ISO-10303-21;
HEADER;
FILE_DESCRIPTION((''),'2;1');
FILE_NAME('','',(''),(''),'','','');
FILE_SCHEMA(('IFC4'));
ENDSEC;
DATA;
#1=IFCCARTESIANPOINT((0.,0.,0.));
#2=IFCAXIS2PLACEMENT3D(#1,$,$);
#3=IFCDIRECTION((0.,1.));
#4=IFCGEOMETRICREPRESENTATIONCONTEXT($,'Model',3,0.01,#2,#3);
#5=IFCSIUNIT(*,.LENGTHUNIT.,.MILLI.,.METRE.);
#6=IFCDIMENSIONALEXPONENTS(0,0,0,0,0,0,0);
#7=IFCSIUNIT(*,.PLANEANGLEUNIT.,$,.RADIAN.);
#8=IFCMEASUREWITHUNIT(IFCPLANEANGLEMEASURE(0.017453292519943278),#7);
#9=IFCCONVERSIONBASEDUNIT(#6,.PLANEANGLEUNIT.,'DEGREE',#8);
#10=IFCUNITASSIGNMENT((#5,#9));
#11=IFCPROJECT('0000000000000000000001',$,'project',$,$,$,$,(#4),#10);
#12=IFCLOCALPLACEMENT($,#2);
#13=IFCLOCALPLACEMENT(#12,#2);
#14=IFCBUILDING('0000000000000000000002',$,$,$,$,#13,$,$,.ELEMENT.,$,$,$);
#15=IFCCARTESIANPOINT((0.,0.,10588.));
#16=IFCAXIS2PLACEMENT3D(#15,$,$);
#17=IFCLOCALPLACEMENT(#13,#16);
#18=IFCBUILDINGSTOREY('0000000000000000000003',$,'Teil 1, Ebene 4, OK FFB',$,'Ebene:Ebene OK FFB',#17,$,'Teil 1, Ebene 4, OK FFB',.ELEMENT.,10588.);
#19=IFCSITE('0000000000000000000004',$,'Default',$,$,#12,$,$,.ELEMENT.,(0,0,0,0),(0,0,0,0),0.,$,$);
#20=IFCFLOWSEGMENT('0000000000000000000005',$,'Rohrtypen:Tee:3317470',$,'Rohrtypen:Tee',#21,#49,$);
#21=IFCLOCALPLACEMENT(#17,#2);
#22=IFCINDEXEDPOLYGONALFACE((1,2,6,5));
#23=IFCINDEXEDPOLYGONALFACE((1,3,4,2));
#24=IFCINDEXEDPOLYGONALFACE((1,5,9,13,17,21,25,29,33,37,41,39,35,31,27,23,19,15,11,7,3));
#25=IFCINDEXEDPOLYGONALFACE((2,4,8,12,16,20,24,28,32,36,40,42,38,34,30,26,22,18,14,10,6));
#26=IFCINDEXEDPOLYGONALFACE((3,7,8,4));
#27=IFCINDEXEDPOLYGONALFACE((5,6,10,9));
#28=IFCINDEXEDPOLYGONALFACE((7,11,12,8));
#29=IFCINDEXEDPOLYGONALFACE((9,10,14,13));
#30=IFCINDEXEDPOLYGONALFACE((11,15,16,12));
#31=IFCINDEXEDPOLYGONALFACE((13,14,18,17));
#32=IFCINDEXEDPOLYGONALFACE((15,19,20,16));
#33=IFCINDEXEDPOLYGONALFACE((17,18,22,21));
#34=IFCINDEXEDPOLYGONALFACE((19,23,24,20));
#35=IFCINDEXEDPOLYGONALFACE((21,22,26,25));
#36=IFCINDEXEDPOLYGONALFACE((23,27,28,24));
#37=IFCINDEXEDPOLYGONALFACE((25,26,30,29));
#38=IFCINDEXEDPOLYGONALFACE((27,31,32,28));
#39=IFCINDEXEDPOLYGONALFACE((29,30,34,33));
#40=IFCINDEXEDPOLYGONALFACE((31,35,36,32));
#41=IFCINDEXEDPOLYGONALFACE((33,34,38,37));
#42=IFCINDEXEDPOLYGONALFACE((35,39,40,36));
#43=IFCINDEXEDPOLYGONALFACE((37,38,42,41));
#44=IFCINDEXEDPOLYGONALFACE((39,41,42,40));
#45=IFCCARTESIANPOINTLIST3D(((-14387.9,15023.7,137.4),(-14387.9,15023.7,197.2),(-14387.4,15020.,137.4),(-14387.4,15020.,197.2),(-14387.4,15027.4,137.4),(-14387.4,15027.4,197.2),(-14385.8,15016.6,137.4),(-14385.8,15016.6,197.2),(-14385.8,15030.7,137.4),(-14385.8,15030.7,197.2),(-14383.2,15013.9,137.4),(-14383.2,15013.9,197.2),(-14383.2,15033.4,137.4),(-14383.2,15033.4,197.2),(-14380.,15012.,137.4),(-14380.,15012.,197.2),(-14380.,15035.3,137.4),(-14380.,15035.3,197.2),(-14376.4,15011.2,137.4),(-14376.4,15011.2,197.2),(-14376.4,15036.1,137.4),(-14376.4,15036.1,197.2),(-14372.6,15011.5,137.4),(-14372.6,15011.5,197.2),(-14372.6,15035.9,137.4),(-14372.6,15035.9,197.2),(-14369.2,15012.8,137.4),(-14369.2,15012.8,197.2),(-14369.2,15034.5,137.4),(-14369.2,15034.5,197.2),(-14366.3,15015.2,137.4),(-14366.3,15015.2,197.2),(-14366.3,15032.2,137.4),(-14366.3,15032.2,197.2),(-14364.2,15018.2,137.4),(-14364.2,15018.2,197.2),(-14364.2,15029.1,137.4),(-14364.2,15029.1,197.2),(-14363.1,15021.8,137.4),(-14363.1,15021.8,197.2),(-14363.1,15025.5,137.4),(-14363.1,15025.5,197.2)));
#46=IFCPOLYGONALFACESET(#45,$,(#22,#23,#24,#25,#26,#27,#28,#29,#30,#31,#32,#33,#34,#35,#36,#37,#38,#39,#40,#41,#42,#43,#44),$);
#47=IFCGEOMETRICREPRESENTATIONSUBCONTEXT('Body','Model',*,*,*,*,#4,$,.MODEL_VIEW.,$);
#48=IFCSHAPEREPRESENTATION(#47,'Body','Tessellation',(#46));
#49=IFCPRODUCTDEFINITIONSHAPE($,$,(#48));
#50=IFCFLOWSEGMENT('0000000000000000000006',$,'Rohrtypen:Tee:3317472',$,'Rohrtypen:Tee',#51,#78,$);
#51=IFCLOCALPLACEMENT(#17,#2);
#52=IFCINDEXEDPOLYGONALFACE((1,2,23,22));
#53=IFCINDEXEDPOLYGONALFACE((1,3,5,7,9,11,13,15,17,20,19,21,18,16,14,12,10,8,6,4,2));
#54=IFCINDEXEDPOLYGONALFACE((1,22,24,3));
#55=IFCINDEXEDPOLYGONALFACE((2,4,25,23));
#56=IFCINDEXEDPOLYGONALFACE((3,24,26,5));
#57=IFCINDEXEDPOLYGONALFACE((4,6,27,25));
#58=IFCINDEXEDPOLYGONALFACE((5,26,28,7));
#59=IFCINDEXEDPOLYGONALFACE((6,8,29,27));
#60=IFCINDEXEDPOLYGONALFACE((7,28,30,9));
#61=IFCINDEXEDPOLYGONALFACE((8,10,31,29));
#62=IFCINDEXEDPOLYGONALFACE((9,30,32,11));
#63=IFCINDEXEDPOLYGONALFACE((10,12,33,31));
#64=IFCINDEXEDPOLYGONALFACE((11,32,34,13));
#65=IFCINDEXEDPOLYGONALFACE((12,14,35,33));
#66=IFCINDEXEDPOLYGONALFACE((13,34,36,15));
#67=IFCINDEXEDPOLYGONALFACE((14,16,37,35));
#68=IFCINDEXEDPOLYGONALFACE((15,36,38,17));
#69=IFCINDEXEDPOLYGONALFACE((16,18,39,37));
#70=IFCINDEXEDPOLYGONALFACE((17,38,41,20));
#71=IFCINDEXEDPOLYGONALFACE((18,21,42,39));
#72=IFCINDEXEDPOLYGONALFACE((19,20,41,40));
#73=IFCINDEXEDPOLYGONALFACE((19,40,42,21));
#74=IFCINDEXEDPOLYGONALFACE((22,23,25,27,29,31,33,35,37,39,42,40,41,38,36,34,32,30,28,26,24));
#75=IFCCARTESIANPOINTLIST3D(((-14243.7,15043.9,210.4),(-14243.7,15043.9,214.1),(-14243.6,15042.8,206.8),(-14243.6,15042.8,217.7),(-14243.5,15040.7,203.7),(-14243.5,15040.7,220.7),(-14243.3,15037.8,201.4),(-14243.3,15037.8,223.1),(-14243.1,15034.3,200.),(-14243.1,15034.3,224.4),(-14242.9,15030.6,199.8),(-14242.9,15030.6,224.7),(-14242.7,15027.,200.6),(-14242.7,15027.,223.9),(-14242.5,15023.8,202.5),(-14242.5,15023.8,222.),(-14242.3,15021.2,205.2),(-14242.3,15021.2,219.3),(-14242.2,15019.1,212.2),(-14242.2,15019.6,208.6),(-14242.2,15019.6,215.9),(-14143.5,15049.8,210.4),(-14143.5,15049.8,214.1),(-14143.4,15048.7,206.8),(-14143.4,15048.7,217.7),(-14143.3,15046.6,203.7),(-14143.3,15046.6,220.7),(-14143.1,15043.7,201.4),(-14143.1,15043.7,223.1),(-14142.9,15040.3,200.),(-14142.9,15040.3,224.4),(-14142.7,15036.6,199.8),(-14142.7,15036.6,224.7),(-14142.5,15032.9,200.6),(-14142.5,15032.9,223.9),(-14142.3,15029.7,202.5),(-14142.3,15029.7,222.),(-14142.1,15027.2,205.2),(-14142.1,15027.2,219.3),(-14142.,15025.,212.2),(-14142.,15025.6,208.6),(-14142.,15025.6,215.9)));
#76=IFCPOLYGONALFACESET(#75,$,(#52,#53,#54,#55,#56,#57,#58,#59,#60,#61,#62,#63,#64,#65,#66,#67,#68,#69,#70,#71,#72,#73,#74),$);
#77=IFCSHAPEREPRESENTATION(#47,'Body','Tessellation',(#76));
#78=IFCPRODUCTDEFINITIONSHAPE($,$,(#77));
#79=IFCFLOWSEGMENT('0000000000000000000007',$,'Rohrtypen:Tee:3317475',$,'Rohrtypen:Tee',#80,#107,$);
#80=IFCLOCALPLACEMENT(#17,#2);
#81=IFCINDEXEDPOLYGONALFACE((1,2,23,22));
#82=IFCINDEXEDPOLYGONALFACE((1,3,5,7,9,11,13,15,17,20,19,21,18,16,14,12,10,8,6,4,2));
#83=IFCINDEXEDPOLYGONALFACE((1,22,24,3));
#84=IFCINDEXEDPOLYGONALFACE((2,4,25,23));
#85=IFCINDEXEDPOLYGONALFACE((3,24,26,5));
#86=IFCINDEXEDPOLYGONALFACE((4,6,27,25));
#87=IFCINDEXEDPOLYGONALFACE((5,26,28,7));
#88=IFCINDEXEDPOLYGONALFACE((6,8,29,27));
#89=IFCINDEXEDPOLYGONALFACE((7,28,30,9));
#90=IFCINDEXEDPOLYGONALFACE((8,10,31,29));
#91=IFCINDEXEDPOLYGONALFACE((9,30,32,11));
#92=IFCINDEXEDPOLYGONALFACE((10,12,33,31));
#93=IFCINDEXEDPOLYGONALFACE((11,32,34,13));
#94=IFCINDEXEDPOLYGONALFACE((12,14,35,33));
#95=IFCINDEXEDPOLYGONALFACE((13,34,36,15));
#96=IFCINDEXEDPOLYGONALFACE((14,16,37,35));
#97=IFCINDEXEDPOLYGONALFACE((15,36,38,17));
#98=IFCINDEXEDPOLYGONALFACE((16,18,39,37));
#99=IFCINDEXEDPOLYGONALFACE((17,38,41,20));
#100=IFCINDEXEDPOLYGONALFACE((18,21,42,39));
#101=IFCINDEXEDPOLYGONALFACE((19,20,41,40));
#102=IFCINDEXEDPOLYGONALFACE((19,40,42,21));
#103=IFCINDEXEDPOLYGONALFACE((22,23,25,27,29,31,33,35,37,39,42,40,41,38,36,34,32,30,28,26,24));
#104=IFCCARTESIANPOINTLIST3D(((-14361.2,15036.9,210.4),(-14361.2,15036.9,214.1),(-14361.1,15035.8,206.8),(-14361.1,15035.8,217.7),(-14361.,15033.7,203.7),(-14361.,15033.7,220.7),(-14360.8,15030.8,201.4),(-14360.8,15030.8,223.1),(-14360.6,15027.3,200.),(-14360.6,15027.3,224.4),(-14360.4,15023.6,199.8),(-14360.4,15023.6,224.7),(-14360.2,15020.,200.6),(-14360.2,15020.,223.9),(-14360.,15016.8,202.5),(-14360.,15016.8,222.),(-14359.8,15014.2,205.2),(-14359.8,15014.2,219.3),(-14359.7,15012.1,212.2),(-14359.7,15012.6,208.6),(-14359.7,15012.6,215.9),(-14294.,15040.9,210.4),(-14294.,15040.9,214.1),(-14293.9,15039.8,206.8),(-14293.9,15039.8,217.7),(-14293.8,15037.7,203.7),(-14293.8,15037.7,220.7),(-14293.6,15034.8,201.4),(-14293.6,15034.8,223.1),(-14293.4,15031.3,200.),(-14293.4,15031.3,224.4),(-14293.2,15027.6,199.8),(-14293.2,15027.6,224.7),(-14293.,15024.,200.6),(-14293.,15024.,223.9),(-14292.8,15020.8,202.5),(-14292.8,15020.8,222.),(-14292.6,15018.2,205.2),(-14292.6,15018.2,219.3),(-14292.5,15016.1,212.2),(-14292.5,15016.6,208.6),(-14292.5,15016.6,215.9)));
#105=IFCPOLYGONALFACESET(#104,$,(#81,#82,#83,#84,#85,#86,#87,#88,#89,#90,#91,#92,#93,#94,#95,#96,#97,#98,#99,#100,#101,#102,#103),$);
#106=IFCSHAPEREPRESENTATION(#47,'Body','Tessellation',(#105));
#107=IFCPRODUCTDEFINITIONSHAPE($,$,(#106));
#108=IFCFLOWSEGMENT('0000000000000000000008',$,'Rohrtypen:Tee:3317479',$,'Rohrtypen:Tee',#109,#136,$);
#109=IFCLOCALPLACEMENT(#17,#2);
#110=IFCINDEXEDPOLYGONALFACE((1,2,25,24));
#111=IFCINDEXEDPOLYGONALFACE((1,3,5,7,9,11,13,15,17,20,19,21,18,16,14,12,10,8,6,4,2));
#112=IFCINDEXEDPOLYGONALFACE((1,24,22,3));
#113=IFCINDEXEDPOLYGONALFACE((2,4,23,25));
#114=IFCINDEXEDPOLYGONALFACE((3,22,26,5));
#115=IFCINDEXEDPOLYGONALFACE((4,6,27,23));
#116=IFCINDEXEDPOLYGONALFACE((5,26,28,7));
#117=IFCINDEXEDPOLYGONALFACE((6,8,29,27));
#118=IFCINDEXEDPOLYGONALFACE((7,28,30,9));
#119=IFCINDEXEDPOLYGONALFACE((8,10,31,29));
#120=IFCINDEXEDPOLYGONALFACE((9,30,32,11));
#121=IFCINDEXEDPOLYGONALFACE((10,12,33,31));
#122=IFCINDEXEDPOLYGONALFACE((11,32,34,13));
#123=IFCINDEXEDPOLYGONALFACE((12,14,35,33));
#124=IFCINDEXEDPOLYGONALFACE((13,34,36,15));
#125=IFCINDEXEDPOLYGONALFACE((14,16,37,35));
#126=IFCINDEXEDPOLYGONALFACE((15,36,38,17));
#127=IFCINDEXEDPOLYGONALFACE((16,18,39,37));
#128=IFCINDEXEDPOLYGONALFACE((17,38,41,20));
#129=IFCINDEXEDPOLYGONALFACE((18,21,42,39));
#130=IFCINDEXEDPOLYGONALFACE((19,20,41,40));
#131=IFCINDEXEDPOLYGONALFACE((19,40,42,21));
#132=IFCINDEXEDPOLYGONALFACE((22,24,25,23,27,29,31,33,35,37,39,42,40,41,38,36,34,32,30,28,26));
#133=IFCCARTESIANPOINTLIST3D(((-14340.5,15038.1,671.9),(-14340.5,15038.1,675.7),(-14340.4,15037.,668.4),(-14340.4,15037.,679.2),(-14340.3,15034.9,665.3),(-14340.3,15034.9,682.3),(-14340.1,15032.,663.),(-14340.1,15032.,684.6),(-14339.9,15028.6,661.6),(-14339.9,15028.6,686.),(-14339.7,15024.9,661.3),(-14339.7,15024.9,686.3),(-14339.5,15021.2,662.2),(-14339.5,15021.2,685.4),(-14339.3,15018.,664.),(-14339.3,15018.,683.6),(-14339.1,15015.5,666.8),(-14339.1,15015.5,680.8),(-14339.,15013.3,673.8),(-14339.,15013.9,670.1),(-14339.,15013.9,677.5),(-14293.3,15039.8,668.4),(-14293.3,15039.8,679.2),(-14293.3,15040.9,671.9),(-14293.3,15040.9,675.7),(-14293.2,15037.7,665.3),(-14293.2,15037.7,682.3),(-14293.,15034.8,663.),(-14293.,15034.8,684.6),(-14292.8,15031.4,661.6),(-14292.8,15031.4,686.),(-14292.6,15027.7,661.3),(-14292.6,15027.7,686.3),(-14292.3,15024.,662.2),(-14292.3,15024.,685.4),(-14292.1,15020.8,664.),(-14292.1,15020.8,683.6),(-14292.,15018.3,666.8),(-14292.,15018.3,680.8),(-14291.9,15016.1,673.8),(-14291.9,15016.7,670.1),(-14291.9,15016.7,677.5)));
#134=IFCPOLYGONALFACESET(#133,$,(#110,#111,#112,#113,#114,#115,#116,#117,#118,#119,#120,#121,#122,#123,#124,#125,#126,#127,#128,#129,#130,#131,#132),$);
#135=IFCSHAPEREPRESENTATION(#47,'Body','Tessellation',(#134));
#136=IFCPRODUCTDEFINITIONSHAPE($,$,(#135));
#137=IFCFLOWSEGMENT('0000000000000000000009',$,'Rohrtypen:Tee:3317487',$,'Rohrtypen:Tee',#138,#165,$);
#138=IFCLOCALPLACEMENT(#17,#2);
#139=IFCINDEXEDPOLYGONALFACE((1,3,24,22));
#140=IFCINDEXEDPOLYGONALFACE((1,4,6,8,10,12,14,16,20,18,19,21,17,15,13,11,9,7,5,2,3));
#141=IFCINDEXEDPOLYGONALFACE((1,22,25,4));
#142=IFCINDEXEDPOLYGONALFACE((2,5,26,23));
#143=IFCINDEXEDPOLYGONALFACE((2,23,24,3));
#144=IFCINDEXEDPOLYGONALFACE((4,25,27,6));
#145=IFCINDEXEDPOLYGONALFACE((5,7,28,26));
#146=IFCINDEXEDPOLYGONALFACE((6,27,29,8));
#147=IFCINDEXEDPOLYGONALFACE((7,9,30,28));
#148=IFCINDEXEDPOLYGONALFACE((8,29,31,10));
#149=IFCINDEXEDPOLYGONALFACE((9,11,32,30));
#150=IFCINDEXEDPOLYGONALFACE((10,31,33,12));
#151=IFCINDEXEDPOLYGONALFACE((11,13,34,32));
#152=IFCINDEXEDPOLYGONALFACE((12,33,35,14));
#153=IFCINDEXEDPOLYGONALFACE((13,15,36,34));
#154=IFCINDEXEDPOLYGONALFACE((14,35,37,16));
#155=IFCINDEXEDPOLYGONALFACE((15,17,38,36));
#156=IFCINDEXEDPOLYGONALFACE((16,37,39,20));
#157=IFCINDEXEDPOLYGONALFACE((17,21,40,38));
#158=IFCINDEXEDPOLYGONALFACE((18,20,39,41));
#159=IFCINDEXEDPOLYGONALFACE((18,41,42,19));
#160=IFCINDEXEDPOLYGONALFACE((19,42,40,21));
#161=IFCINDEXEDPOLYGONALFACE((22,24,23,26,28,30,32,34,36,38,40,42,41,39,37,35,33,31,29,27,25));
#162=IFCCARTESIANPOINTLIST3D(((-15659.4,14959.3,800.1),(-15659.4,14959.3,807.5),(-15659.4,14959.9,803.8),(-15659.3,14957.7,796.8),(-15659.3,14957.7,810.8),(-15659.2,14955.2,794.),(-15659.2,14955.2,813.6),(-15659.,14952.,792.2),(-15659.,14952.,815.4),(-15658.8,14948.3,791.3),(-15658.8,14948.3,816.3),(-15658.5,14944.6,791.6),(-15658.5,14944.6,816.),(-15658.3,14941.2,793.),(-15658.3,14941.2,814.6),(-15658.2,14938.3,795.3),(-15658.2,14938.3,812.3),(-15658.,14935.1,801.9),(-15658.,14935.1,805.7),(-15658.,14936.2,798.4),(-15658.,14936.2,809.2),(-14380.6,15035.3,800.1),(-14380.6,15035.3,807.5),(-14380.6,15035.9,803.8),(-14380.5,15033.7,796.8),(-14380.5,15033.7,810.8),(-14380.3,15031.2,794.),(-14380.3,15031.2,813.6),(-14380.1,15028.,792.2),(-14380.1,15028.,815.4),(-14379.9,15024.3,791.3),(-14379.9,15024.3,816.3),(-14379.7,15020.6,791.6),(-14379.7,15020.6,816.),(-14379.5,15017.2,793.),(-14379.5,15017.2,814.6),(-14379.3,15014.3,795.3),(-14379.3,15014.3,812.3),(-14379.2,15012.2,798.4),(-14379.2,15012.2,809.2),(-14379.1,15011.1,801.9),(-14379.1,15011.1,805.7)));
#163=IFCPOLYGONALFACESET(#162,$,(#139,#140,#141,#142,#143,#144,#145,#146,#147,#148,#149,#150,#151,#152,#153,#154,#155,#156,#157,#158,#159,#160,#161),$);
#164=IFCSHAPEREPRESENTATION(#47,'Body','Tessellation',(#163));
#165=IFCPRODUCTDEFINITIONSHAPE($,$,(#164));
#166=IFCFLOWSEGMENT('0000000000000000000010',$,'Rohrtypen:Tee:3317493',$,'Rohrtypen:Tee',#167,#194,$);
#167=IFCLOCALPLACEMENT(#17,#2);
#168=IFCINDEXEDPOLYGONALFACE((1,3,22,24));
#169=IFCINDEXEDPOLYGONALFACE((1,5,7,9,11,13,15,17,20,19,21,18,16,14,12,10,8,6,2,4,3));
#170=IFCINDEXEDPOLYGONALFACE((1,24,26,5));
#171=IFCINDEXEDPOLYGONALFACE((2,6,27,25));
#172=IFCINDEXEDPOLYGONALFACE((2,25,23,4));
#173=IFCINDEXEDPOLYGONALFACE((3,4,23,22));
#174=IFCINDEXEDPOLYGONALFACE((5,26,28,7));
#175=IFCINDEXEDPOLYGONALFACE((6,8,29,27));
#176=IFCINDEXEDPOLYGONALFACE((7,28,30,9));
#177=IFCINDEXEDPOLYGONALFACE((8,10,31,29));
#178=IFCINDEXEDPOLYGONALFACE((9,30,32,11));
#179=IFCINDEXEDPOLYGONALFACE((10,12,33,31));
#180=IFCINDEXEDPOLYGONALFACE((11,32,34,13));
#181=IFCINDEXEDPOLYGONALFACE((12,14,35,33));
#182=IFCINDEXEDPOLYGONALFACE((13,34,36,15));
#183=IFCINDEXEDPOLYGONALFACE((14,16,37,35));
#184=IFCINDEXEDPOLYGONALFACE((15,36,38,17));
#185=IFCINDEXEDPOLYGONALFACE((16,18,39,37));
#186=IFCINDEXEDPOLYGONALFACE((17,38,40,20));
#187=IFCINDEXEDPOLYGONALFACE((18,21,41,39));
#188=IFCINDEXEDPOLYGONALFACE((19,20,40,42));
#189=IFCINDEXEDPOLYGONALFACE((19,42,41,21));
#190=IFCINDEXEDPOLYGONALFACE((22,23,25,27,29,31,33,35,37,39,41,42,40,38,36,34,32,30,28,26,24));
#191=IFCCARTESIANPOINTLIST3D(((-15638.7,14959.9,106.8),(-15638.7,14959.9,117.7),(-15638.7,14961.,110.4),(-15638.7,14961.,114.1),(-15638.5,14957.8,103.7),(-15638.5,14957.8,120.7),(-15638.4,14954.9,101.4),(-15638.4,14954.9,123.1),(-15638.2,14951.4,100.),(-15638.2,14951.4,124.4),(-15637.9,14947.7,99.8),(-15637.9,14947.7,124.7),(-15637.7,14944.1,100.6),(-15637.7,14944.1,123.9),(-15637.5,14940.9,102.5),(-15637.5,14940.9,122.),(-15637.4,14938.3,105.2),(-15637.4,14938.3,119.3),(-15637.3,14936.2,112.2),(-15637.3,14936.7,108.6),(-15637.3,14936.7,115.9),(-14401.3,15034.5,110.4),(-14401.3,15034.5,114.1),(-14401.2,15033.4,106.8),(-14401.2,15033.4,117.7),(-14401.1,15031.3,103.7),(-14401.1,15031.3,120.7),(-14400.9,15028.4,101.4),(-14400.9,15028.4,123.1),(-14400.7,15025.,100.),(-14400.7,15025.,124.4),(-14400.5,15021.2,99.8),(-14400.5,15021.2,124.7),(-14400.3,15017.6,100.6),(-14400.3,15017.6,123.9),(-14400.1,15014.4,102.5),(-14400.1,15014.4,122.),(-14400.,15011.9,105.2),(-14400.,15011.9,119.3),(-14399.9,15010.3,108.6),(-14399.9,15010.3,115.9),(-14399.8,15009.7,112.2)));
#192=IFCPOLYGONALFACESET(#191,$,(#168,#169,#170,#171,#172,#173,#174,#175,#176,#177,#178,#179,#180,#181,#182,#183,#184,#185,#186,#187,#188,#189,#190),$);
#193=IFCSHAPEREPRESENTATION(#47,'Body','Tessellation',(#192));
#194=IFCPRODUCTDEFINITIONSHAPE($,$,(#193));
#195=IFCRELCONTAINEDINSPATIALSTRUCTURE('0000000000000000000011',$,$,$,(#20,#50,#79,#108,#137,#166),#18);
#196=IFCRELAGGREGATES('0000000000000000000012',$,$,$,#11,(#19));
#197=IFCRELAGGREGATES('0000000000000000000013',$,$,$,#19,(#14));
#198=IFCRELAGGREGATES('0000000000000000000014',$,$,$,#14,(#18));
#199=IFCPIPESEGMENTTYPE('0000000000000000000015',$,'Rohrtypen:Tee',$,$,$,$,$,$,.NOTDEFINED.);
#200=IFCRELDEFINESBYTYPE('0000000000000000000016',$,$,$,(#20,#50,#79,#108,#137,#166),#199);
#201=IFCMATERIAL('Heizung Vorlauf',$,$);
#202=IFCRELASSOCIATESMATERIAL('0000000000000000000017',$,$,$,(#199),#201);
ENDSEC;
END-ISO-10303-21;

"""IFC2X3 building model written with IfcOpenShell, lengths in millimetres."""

from ifc_helpers import new_model, entity, si_unit, converted_unit, direction, frame, frame_2d, origin, origin_2d_with_axis, place, context, subcontext, project, spatial, circle, extrude, material, type_object, element, save


model = new_model("IFC2X3")

# Units and contexts
model_context = context("Model", 3, precision=0.01, world=origin(), true_north=direction((0.0, 1.0)))
body_context = subcontext(model_context, "Body", "Model", "MODEL_VIEW")
ifc_project = project(units=[si_unit("LENGTHUNIT", "METRE", prefix="MILLI"), converted_unit("PLANEANGLEUNIT", "DEGREE", entity("IfcPlaneAngleMeasure", 0.017453292519943278), si_unit("PLANEANGLEUNIT", "RADIAN"), dimensions=[0, 0, 0, 0, 0, 0, 0])], contexts=[model_context])

# Site, building, storey
site_placement = place(None, origin())
site = spatial("IfcSite", under=ifc_project, at=site_placement, Name="Default", CompositionType="ELEMENT", RefLatitude=(0, 0, 0, 0), RefLongitude=(0, 0, 0, 0), RefElevation=0.0)
building_placement = place(site_placement, origin())
building = spatial("IfcBuilding", under=site, at=building_placement, CompositionType="ELEMENT")
storey_placement = place(building_placement, frame((0.0, 0.0, 10588.0)))
storey = spatial("IfcBuildingStorey", under=building, at=storey_placement, Name="Teil 1, Ebene 4, OK FFB", ObjectType="Ebene:Ebene OK FFB", LongName="Teil 1, Ebene 4, OK FFB", CompositionType="ELEMENT", Elevation=10588.0)

# Flow segments
ifc_material = material(Name="Heizung Vorlauf")
pipe_segment_type = type_object("IfcPipeSegmentType", Name="Rohrtypen:Tee", PredefinedType="NOTDEFINED", material=ifc_material)
flow_segment_1_placement = place(storey_placement, origin())
element("IfcFlowSegment", 1, at=flow_segment_1_placement, inside=storey, type_object=pipe_segment_type, Name="Rohrtypen:Tee:3317470", ObjectType="Rohrtypen:Tee", context=body_context, shape_type="SweptSolid", body=[
    extrude(circle(Radius=12.5, at=frame_2d((0.0, 0.0), x_axis=(1.0, 0.0))), frame((-14375.4, 15023.7, 137.4), z_axis=(0.0, 0.0, 1.0), x_axis=(-1.0, 0.0, 0.0)), (0.0, 0.0, 1.0), 59.8),
])
flow_segment_2_placement = place(storey_placement, origin())
element("IfcFlowSegment", 2, at=flow_segment_2_placement, inside=storey, type_object=pipe_segment_type, Name="Rohrtypen:Tee:3317472", ObjectType="Rohrtypen:Tee", context=body_context, shape_type="SweptSolid", body=[
    extrude(circle(Radius=12.5, at=frame_2d((0.0, 0.0), x_axis=(1.0, 0.0))), frame((-14242.9, 15031.5, 212.2), z_axis=(0.998239, 0.059319, 0.0), x_axis=(0.059319, -0.998239, 0.0)), (0.0, 0.0, 1.0), 100.4),
])
flow_segment_3_placement = place(storey_placement, origin())
element("IfcFlowSegment", 3, at=flow_segment_3_placement, inside=storey, type_object=pipe_segment_type, Name="Rohrtypen:Tee:3317475", ObjectType="Rohrtypen:Tee", context=body_context, shape_type="SweptSolid", body=[
    extrude(circle(Radius=12.5, at=frame_2d((0.0, 0.0), x_axis=(1.0, 0.0))), frame((-14360.4, 15024.6, 212.2), z_axis=(0.998239, 0.059319, 0.0), x_axis=(0.059319, -0.998239, 0.0)), (0.0, 0.0, 1.0), 67.3),
])
flow_segment_4_placement = place(storey_placement, origin())
element("IfcFlowSegment", 4, at=flow_segment_4_placement, inside=storey, type_object=pipe_segment_type, Name="Rohrtypen:Tee:3317479", ObjectType="Rohrtypen:Tee", context=body_context, shape_type="SweptSolid", body=[
    extrude(circle(Radius=12.5, at=origin_2d_with_axis()), frame((-14339.7, 15025.8, 673.8), z_axis=(0.998239, 0.059319, 0.0), x_axis=(0.059319, -0.998239, 0.0)), (0.0, 0.0, 1.0), 47.2),
])
flow_segment_5_placement = place(storey_placement, origin())
element("IfcFlowSegment", 5, at=flow_segment_5_placement, inside=storey, type_object=pipe_segment_type, Name="Rohrtypen:Tee:3317487", ObjectType="Rohrtypen:Tee", context=body_context, shape_type="SweptSolid", body=[
    extrude(circle(Radius=12.5, at=origin_2d_with_axis()), frame((-15658.7, 14947.4, 803.8), z_axis=(0.998239, 0.059319, 0.0), x_axis=(-0.059319, 0.998239, 0.0)), (0.0, 0.0, 1.0), 1281.1),
])
flow_segment_6_placement = place(storey_placement, origin())
element("IfcFlowSegment", 6, at=flow_segment_6_placement, inside=storey, type_object=pipe_segment_type, Name="Rohrtypen:Tee:3317493", ObjectType="Rohrtypen:Tee", context=body_context, shape_type="SweptSolid", body=[
    extrude(circle(Radius=12.5, at=origin_2d_with_axis()), frame((-15638.0, 14948.6, 112.2), z_axis=(0.998239, 0.059319, 0.0), x_axis=(0.059319, -0.998239, 0.0)), (0.0, 0.0, 1.0), 1239.6),
])

save(model, "model.ifc")
